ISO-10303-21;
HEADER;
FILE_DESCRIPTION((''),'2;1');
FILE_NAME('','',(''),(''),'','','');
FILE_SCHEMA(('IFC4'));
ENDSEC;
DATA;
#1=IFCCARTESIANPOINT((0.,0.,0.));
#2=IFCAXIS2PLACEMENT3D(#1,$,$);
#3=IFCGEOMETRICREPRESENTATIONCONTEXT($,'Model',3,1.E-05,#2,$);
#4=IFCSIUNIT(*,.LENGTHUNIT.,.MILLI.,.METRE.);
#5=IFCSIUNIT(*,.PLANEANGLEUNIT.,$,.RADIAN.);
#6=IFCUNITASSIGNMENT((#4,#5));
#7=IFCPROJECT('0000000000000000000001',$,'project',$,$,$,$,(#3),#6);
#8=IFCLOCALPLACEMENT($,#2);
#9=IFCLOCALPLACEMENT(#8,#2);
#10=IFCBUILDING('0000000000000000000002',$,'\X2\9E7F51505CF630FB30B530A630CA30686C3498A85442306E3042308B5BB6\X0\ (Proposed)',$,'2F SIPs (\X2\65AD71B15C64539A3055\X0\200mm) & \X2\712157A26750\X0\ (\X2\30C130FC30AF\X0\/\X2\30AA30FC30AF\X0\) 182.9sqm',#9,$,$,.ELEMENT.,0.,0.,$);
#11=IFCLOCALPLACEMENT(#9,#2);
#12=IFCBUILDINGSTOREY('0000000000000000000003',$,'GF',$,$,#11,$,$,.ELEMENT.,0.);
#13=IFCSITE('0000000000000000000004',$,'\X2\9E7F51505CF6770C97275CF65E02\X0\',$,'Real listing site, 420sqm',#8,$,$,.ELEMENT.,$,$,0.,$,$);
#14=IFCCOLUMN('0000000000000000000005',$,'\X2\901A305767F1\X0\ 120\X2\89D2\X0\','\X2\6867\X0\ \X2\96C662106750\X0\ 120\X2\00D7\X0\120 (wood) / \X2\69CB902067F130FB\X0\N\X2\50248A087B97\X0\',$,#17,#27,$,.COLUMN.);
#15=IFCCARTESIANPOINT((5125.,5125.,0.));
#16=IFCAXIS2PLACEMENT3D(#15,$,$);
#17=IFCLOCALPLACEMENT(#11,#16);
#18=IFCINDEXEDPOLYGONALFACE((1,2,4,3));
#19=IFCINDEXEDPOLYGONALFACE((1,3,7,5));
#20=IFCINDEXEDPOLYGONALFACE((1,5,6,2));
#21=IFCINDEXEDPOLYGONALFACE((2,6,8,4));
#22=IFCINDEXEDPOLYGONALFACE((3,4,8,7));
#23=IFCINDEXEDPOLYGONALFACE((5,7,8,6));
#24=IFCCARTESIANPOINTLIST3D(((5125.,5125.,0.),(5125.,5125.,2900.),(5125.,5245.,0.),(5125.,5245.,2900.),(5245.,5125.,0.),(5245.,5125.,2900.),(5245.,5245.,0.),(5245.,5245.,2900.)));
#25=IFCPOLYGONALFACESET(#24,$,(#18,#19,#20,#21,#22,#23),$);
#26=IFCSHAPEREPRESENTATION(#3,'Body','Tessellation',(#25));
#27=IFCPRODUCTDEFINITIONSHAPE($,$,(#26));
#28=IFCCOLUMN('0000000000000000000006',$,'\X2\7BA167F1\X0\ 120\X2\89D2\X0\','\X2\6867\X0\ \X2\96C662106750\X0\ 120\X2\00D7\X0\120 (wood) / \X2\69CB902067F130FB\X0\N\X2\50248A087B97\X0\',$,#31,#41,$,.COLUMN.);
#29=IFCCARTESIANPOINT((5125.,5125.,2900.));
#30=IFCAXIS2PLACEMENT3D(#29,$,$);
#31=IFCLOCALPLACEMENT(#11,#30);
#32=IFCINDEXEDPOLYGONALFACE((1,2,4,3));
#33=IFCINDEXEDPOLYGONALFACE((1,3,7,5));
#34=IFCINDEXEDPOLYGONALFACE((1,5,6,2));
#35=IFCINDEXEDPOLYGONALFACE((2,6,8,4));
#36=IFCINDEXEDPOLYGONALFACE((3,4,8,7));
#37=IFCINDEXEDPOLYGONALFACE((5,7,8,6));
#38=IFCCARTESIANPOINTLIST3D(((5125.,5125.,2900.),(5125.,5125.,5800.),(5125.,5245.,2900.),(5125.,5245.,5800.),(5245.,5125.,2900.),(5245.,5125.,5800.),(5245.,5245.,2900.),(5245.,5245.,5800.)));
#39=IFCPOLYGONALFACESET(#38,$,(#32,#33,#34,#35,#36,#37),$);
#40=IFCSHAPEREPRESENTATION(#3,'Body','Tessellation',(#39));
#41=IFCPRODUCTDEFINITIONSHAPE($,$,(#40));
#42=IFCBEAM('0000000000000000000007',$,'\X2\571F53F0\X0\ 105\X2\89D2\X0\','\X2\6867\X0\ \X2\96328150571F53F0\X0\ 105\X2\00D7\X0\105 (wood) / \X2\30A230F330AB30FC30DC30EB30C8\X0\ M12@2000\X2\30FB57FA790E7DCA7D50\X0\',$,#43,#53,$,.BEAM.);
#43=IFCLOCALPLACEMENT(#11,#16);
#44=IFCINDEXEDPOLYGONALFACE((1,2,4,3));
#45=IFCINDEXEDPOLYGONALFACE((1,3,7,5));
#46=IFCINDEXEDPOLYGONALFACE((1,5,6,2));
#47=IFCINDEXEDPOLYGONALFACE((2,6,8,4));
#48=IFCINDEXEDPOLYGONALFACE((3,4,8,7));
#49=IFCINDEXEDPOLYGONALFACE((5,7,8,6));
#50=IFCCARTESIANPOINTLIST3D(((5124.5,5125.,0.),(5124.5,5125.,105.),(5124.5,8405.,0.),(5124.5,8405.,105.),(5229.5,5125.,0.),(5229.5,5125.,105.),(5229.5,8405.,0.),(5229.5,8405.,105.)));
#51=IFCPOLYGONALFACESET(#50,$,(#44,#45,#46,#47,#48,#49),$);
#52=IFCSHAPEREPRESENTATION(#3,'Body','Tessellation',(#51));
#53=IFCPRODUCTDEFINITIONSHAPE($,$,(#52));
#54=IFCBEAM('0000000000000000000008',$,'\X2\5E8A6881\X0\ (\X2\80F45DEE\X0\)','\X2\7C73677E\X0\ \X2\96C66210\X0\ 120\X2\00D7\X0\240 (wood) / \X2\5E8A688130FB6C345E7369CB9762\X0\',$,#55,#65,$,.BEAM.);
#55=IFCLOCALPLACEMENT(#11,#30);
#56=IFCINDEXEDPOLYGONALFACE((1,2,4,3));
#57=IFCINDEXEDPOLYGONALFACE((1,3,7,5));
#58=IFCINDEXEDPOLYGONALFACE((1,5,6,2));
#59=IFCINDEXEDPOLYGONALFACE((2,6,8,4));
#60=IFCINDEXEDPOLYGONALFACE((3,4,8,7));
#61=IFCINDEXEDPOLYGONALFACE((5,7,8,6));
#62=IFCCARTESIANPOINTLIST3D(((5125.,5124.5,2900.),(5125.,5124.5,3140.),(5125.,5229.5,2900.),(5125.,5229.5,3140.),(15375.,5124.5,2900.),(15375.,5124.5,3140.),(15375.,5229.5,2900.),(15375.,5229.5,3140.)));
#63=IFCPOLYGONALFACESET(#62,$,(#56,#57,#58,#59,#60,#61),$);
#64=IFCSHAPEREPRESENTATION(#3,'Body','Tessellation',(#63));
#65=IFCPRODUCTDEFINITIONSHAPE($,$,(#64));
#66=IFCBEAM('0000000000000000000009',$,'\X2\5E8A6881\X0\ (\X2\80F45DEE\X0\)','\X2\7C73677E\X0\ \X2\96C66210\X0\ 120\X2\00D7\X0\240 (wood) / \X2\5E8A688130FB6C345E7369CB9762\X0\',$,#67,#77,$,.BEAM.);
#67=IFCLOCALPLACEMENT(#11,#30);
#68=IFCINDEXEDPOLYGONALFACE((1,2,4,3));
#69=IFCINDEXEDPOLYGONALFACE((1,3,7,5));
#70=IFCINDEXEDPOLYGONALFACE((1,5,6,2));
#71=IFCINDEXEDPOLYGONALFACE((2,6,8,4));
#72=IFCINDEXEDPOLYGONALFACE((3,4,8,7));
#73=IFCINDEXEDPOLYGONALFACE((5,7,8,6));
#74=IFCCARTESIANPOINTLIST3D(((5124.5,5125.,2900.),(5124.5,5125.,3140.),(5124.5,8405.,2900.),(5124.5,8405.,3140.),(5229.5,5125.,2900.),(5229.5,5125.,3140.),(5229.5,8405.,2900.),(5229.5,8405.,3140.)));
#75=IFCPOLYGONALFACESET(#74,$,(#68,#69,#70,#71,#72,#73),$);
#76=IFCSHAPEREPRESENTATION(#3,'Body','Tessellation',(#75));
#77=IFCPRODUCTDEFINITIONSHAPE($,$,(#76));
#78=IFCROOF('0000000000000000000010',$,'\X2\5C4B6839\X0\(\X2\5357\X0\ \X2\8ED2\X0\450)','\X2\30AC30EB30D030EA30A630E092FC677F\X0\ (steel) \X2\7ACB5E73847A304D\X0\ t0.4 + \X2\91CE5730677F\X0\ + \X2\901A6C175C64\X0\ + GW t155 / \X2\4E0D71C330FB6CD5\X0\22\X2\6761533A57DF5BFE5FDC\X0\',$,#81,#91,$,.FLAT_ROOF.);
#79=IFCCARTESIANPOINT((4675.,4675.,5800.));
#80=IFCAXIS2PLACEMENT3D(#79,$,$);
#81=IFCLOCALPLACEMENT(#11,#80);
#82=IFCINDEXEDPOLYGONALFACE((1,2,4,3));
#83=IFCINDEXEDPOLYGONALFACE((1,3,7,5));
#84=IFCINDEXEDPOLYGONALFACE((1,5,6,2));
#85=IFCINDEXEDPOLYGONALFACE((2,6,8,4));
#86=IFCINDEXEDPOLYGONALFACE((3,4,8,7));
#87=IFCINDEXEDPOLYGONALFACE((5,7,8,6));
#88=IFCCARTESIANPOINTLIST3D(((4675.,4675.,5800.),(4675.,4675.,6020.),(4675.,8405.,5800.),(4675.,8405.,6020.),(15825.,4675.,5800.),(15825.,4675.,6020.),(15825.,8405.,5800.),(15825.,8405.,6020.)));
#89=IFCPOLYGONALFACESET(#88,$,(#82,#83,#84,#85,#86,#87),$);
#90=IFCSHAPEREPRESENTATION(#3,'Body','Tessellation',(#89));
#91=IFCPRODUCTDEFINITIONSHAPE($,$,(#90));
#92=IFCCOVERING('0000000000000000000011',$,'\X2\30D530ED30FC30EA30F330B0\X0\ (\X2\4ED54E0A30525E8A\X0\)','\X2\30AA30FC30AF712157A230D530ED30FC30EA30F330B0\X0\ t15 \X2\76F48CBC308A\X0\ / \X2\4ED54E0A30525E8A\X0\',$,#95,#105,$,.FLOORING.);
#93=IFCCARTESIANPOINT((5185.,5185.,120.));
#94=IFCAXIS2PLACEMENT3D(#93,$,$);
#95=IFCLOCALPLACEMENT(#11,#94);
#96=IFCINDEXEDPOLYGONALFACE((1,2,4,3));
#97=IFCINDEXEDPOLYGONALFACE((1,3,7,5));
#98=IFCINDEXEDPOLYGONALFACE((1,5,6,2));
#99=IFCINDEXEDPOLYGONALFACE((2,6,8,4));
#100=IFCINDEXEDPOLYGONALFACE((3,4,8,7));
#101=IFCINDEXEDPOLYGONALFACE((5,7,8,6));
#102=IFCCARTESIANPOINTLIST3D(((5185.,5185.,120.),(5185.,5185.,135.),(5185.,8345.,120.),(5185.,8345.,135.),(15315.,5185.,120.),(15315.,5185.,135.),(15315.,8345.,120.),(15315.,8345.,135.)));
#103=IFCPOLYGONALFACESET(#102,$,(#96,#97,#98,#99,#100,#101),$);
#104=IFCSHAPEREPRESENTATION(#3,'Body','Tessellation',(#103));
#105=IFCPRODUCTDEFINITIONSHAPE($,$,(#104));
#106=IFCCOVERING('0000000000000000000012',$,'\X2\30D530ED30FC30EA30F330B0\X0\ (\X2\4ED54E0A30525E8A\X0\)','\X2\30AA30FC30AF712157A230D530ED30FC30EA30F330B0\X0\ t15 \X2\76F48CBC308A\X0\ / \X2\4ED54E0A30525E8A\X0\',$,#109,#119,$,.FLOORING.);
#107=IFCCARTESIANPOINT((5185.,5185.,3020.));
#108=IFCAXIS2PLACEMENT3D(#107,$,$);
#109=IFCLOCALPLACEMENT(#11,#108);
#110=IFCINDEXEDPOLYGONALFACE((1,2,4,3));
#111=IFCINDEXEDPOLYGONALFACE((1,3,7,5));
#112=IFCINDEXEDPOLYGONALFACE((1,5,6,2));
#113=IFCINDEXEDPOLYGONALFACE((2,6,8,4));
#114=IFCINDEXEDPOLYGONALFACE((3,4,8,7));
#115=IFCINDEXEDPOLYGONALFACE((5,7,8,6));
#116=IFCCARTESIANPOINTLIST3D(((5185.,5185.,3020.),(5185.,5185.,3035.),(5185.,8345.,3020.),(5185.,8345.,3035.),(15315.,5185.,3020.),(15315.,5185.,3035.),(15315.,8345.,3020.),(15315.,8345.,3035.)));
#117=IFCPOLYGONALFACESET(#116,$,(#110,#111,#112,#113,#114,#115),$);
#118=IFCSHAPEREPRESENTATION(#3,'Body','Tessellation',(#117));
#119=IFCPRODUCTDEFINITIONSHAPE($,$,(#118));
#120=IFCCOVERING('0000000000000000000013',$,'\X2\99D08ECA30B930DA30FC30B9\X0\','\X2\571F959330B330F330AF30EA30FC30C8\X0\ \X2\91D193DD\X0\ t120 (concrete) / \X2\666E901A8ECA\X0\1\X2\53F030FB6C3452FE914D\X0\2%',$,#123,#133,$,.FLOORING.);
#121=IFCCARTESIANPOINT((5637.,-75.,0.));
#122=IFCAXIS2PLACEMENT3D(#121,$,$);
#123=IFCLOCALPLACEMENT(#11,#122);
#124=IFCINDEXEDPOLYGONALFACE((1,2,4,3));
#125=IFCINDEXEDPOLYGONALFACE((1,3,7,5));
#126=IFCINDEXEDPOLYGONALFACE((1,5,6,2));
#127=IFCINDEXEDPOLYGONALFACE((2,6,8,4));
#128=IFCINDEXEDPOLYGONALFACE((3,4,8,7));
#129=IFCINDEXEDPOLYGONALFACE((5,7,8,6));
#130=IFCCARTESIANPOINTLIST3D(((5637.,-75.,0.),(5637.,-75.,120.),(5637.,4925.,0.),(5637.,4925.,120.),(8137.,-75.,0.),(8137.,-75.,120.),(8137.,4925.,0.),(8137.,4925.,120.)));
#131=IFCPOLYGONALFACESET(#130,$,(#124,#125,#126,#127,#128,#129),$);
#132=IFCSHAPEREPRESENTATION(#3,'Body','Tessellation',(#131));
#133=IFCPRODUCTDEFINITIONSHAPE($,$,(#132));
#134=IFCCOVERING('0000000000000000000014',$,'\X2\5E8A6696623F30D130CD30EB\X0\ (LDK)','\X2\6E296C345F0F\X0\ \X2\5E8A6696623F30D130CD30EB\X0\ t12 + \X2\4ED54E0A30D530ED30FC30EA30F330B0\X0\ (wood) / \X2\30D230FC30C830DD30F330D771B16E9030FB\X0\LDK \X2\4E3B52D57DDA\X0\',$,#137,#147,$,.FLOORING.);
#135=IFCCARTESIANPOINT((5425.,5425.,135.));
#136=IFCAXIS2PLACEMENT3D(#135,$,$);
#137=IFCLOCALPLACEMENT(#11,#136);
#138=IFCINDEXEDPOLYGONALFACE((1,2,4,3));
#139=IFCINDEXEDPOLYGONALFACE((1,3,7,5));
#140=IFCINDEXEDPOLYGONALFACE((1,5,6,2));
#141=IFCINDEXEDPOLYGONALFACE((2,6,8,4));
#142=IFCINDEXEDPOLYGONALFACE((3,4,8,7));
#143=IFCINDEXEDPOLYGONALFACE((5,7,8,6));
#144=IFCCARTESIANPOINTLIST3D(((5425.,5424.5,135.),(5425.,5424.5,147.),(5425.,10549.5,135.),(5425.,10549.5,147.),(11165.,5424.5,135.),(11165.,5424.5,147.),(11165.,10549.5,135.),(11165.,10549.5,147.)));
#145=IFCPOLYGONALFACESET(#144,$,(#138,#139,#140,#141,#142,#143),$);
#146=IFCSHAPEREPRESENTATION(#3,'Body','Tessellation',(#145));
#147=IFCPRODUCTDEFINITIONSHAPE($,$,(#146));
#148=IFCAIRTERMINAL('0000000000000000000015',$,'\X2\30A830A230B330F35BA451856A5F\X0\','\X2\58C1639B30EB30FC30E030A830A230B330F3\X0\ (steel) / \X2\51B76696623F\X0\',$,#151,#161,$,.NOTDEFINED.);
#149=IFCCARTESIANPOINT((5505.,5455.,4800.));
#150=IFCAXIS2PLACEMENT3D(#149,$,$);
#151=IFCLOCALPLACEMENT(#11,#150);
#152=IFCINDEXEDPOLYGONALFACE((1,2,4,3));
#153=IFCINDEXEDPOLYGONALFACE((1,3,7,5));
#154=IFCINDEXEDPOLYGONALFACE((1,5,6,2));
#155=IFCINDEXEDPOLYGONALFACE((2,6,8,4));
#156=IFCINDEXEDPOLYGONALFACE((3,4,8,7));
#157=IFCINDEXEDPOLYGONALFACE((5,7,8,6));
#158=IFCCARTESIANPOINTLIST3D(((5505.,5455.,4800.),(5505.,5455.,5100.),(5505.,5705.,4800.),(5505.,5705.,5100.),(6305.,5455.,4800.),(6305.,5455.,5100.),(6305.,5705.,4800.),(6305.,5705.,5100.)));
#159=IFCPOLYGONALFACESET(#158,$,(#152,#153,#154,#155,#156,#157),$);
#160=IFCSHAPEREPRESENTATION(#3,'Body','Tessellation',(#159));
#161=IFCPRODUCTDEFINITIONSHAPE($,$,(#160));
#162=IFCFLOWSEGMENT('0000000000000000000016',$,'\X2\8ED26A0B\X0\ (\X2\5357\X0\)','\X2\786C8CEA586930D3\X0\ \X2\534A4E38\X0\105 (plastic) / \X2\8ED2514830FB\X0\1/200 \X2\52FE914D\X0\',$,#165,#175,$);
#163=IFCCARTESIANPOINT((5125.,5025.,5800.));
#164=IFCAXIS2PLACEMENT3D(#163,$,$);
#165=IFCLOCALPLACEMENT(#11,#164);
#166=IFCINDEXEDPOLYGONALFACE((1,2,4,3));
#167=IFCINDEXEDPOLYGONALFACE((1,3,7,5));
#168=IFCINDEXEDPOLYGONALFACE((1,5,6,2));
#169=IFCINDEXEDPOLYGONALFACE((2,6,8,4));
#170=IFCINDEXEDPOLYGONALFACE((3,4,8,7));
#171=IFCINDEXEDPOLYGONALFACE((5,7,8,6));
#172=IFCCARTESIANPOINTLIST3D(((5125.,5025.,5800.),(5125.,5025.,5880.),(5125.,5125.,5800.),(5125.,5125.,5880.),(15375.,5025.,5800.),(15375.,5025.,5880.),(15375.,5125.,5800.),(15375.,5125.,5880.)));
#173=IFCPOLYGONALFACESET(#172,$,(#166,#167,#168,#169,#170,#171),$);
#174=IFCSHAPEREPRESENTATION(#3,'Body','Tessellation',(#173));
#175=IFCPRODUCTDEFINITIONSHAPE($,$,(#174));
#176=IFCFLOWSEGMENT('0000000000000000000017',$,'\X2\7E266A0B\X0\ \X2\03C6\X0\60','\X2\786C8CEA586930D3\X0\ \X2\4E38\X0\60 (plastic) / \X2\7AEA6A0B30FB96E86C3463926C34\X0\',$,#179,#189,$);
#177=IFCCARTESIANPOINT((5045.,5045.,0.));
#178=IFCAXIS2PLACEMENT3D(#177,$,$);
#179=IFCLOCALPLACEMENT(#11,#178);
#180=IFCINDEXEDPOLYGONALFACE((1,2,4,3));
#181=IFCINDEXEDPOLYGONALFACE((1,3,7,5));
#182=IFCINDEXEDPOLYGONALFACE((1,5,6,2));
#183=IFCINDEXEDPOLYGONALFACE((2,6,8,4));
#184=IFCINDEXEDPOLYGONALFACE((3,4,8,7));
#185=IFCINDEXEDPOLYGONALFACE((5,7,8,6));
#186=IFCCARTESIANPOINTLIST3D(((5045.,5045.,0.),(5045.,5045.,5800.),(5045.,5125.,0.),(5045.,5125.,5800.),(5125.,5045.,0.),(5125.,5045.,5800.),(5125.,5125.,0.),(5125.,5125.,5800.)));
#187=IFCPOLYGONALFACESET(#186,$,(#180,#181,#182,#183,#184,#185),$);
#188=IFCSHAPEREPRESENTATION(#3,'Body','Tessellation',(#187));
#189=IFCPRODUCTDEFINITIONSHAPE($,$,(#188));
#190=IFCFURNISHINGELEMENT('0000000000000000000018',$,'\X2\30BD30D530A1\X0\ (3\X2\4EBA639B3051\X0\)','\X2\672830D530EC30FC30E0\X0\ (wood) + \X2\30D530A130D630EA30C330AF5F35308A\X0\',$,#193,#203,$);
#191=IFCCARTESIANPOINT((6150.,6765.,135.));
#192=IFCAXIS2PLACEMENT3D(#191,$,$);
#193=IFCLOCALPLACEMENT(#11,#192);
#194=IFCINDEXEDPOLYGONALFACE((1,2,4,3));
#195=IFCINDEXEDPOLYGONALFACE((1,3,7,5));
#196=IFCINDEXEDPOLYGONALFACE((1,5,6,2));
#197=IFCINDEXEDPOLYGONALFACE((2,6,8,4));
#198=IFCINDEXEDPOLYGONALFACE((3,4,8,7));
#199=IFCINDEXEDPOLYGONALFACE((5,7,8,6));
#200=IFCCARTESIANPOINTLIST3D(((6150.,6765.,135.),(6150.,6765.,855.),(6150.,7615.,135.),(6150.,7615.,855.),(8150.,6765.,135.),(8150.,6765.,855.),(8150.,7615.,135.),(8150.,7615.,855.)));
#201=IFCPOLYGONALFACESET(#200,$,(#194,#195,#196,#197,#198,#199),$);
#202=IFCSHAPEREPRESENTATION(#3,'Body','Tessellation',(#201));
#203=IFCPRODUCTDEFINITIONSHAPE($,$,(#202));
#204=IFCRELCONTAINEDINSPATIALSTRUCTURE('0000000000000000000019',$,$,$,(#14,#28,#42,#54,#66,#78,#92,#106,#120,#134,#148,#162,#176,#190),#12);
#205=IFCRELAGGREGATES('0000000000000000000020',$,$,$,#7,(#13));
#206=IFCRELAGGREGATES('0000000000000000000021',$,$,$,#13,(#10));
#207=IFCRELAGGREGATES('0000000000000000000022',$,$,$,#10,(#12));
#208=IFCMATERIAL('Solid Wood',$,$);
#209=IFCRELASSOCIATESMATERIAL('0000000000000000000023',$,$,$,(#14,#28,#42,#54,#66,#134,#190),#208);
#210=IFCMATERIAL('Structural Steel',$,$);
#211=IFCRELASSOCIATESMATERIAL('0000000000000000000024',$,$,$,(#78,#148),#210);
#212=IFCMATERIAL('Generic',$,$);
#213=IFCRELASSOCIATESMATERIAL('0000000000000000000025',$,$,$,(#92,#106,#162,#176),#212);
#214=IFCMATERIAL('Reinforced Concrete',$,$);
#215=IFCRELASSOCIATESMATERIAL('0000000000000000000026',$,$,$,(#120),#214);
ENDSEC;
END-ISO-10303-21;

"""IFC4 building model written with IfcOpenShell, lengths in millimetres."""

from ifc_helpers import new_model, si_unit, frame, frame_2d, origin, place, context, project, spatial, rectangle, extrude, material, element, save


model = new_model("IFC4")

# Units and contexts
model_context = context("Model", 3, precision=1e-05, world=origin())
ifc_project = project(units=[si_unit("LENGTHUNIT", "METRE", prefix="MILLI"), si_unit("PLANEANGLEUNIT", "RADIAN")], contexts=[model_context])

# Site, building, storey
site_placement = place(None, origin())
site = spatial("IfcSite", under=ifc_project, at=site_placement, Name="鹿児島県霧島市", ObjectType="Real listing site, 420sqm", CompositionType="ELEMENT", RefElevation=0.0)
building_placement = place(site_placement, origin())
building = spatial("IfcBuilding", under=site, at=building_placement, Name="鹿児島・サウナと水風呂のある家 (Proposed)", ObjectType="2F SIPs (断熱層厚さ200mm) & 無垢材 (チーク/オーク) 182.9sqm", CompositionType="ELEMENT", ElevationOfRefHeight=0.0, ElevationOfTerrain=0.0)
storey_placement = place(building_placement, origin())
storey = spatial("IfcBuildingStorey", under=building, at=storey_placement, Name="GF", CompositionType="ELEMENT", Elevation=0.0)

# Columns
ifc_material_1 = material(Name="Solid Wood")
column_1_placement = place(storey_placement, frame((5125.0, 5125.0, 0.0)))
element("IfcColumn", 1, at=column_1_placement, inside=storey, material=ifc_material_1, Name="通し柱 120角", Description="桧 集成材 120×120 (wood) / 構造柱・N値計算", PredefinedType="COLUMN", context=model_context, shape_type="SweptSolid", body=[
    extrude(rectangle(XDim=120.0, YDim=120.0, at=frame_2d((60.0, 60.0))), frame((5125.0, 5125.0, 0.0)), (0.0, 0.0, 1.0), 2900.0),
])
column_2_placement = place(storey_placement, frame((5125.0, 5125.0, 2900.0)))
element("IfcColumn", 2, at=column_2_placement, inside=storey, material=ifc_material_1, Name="管柱 120角", Description="桧 集成材 120×120 (wood) / 構造柱・N値計算", PredefinedType="COLUMN", context=model_context, shape_type="SweptSolid", body=[
    extrude(rectangle(XDim=120.0, YDim=120.0, at=frame_2d((60.0, 60.0))), frame((5125.0, 5125.0, 2900.0)), (0.0, 0.0, 1.0), 2900.0),
])

# Beams
beam_1_placement = place(storey_placement, frame((5125.0, 5125.0, 0.0)))
element("IfcBeam", 3, at=beam_1_placement, inside=storey, material=ifc_material_1, Name="土台 105角", Description="桧 防腐土台 105×105 (wood) / アンカーボルト M12@2000・基礎緊結", PredefinedType="BEAM", context=model_context, shape_type="SweptSolid", body=[
    extrude(rectangle(XDim=105.0, YDim=3280.0, at=frame_2d((52.0, 1640.0))), frame((5125.0, 5125.0, 0.0)), (0.0, 0.0, 1.0), 105.0),
])
beam_2_placement = place(storey_placement, frame((5125.0, 5125.0, 2900.0)))
element("IfcBeam", 4, at=beam_2_placement, inside=storey, material=ifc_material_1, Name="床梁 (胴差)", Description="米松 集成 120×240 (wood) / 床梁・水平構面", PredefinedType="BEAM", context=model_context, shape_type="SweptSolid", body=[
    extrude(rectangle(XDim=10250.0, YDim=105.0, at=frame_2d((5125.0, 52.0))), frame((5125.0, 5125.0, 2900.0)), (0.0, 0.0, 1.0), 240.0),
])
beam_3_placement = place(storey_placement, frame((5125.0, 5125.0, 2900.0)))
element("IfcBeam", 5, at=beam_3_placement, inside=storey, material=ifc_material_1, Name="床梁 (胴差)", Description="米松 集成 120×240 (wood) / 床梁・水平構面", PredefinedType="BEAM", context=model_context, shape_type="SweptSolid", body=[
    extrude(rectangle(XDim=105.0, YDim=3280.0, at=frame_2d((52.0, 1640.0))), frame((5125.0, 5125.0, 2900.0)), (0.0, 0.0, 1.0), 240.0),
])

# Shared definitions
ifc_material_2 = material(Name="Reinforced Concrete")

# Roof
ifc_material_3 = material(Name="Structural Steel")
for number, where, name in (
    (6, (4675.0, 4675.0, 5800.0), "屋根(南 軒450)"),
):
    element("IfcRoof", number, at=place(storey_placement, frame(where)), inside=storey, material=ifc_material_3, Name=name, Description="ガルバリウム鋼板 (steel) 立平葺き t0.4 + 野地板 + 通気層 + GW t155 / 不燃・法22条区域対応", PredefinedType="FLAT_ROOF", context=model_context, shape_type="SweptSolid", body=[
        extrude(rectangle(XDim=11150.0, YDim=3730.0, at=frame_2d((5575.0, 1865.0))), frame((4675.0, 4675.0, 5800.0)), (0.0, 0.0, 1.0), 220.0),
    ])

# Coverings
ifc_material_4 = material(Name="Generic")
covering_1_placement = place(storey_placement, frame((5185.0, 5185.0, 120.0)))
element("IfcCovering", 7, at=covering_1_placement, inside=storey, material=ifc_material_4, Name="フローリング (仕上げ床)", Description="オーク無垢フローリング t15 直貼り / 仕上げ床", PredefinedType="FLOORING", context=model_context, shape_type="SweptSolid", body=[
    extrude(rectangle(XDim=10130.0, YDim=3160.0, at=frame_2d((5065.0, 1580.0))), frame((5185.0, 5185.0, 120.0)), (0.0, 0.0, 1.0), 15.0),
])
covering_2_placement = place(storey_placement, frame((5185.0, 5185.0, 3020.0)))
element("IfcCovering", 8, at=covering_2_placement, inside=storey, material=ifc_material_4, Name="フローリング (仕上げ床)", Description="オーク無垢フローリング t15 直貼り / 仕上げ床", PredefinedType="FLOORING", context=model_context, shape_type="SweptSolid", body=[
    extrude(rectangle(XDim=10130.0, YDim=3160.0, at=frame_2d((5065.0, 1580.0))), frame((5185.0, 5185.0, 3020.0)), (0.0, 0.0, 1.0), 15.0),
])
covering_3_placement = place(storey_placement, frame((5637.0, -75.0, 0.0)))
element("IfcCovering", 9, at=covering_3_placement, inside=storey, material=ifc_material_2, Name="駐車スペース", Description="土間コンクリート 金鏝 t120 (concrete) / 普通車1台・水勾配2%", PredefinedType="FLOORING", context=model_context, shape_type="SweptSolid", body=[
    extrude(rectangle(XDim=2500.0, YDim=5000.0, at=frame_2d((1250.0, 2500.0))), frame((5637.0, -75.0, 0.0)), (0.0, 0.0, 1.0), 120.0),
])
covering_4_placement = place(storey_placement, frame((5425.0, 5425.0, 135.0)))
element("IfcCovering", 10, at=covering_4_placement, inside=storey, material=ifc_material_1, Name="床暖房パネル (LDK)", Description="温水式 床暖房パネル t12 + 仕上フローリング (wood) / ヒートポンプ熱源・LDK 主動線", PredefinedType="FLOORING", context=model_context, shape_type="SweptSolid", body=[
    extrude(rectangle(XDim=5740.0, YDim=5125.0, at=frame_2d((2870.0, 2562.0))), frame((5425.0, 5425.0, 135.0)), (0.0, 0.0, 1.0), 12.0),
])

# Air terminal
air_terminal_placement = place(storey_placement, frame((5505.0, 5455.0, 4800.0)))
element("IfcAirTerminal", 11, at=air_terminal_placement, inside=storey, material=ifc_material_3, Name="エアコン室内機", Description="壁掛ルームエアコン (steel) / 冷暖房", PredefinedType="NOTDEFINED", context=model_context, shape_type="SweptSolid", body=[
    extrude(rectangle(XDim=800.0, YDim=250.0, at=frame_2d((400.0, 125.0))), frame((5505.0, 5455.0, 4800.0)), (0.0, 0.0, 1.0), 300.0),
])

# Flow segments
flow_segment_1_placement = place(storey_placement, frame((5125.0, 5025.0, 5800.0)))
element("IfcFlowSegment", 12, at=flow_segment_1_placement, inside=storey, material=ifc_material_4, Name="軒樋 (南)", Description="硬質塩ビ 半丸105 (plastic) / 軒先・1/200 勾配", context=model_context, shape_type="SweptSolid", body=[
    extrude(rectangle(XDim=10250.0, YDim=100.0, at=frame_2d((5125.0, 50.0))), frame((5125.0, 5025.0, 5800.0)), (0.0, 0.0, 1.0), 80.0),
])
flow_segment_2_placement = place(storey_placement, frame((5045.0, 5045.0, 0.0)))
element("IfcFlowSegment", 13, at=flow_segment_2_placement, inside=storey, material=ifc_material_4, Name="縦樋 φ60", Description="硬質塩ビ 丸60 (plastic) / 竪樋・雨水排水", context=model_context, shape_type="SweptSolid", body=[
    extrude(rectangle(XDim=80.0, YDim=80.0, at=frame_2d((40.0, 40.0))), frame((5045.0, 5045.0, 0.0)), (0.0, 0.0, 1.0), 5800.0),
])

# Furnishing element
furnishing_1_placement = place(storey_placement, frame((6150.0, 6765.0, 135.0)))
element("IfcFurnishingElement", 14, at=furnishing_1_placement, inside=storey, material=ifc_material_1, Name="ソファ (3人掛け)", Description="木フレーム (wood) + ファブリック張り", context=model_context, shape_type="SweptSolid", body=[
    extrude(rectangle(XDim=2000.0, YDim=850.0, at=frame_2d((1000.0, 425.0))), frame((6150.0, 6765.0, 135.0)), (0.0, 0.0, 1.0), 720.0),
])

save(model, "model.ifc")
